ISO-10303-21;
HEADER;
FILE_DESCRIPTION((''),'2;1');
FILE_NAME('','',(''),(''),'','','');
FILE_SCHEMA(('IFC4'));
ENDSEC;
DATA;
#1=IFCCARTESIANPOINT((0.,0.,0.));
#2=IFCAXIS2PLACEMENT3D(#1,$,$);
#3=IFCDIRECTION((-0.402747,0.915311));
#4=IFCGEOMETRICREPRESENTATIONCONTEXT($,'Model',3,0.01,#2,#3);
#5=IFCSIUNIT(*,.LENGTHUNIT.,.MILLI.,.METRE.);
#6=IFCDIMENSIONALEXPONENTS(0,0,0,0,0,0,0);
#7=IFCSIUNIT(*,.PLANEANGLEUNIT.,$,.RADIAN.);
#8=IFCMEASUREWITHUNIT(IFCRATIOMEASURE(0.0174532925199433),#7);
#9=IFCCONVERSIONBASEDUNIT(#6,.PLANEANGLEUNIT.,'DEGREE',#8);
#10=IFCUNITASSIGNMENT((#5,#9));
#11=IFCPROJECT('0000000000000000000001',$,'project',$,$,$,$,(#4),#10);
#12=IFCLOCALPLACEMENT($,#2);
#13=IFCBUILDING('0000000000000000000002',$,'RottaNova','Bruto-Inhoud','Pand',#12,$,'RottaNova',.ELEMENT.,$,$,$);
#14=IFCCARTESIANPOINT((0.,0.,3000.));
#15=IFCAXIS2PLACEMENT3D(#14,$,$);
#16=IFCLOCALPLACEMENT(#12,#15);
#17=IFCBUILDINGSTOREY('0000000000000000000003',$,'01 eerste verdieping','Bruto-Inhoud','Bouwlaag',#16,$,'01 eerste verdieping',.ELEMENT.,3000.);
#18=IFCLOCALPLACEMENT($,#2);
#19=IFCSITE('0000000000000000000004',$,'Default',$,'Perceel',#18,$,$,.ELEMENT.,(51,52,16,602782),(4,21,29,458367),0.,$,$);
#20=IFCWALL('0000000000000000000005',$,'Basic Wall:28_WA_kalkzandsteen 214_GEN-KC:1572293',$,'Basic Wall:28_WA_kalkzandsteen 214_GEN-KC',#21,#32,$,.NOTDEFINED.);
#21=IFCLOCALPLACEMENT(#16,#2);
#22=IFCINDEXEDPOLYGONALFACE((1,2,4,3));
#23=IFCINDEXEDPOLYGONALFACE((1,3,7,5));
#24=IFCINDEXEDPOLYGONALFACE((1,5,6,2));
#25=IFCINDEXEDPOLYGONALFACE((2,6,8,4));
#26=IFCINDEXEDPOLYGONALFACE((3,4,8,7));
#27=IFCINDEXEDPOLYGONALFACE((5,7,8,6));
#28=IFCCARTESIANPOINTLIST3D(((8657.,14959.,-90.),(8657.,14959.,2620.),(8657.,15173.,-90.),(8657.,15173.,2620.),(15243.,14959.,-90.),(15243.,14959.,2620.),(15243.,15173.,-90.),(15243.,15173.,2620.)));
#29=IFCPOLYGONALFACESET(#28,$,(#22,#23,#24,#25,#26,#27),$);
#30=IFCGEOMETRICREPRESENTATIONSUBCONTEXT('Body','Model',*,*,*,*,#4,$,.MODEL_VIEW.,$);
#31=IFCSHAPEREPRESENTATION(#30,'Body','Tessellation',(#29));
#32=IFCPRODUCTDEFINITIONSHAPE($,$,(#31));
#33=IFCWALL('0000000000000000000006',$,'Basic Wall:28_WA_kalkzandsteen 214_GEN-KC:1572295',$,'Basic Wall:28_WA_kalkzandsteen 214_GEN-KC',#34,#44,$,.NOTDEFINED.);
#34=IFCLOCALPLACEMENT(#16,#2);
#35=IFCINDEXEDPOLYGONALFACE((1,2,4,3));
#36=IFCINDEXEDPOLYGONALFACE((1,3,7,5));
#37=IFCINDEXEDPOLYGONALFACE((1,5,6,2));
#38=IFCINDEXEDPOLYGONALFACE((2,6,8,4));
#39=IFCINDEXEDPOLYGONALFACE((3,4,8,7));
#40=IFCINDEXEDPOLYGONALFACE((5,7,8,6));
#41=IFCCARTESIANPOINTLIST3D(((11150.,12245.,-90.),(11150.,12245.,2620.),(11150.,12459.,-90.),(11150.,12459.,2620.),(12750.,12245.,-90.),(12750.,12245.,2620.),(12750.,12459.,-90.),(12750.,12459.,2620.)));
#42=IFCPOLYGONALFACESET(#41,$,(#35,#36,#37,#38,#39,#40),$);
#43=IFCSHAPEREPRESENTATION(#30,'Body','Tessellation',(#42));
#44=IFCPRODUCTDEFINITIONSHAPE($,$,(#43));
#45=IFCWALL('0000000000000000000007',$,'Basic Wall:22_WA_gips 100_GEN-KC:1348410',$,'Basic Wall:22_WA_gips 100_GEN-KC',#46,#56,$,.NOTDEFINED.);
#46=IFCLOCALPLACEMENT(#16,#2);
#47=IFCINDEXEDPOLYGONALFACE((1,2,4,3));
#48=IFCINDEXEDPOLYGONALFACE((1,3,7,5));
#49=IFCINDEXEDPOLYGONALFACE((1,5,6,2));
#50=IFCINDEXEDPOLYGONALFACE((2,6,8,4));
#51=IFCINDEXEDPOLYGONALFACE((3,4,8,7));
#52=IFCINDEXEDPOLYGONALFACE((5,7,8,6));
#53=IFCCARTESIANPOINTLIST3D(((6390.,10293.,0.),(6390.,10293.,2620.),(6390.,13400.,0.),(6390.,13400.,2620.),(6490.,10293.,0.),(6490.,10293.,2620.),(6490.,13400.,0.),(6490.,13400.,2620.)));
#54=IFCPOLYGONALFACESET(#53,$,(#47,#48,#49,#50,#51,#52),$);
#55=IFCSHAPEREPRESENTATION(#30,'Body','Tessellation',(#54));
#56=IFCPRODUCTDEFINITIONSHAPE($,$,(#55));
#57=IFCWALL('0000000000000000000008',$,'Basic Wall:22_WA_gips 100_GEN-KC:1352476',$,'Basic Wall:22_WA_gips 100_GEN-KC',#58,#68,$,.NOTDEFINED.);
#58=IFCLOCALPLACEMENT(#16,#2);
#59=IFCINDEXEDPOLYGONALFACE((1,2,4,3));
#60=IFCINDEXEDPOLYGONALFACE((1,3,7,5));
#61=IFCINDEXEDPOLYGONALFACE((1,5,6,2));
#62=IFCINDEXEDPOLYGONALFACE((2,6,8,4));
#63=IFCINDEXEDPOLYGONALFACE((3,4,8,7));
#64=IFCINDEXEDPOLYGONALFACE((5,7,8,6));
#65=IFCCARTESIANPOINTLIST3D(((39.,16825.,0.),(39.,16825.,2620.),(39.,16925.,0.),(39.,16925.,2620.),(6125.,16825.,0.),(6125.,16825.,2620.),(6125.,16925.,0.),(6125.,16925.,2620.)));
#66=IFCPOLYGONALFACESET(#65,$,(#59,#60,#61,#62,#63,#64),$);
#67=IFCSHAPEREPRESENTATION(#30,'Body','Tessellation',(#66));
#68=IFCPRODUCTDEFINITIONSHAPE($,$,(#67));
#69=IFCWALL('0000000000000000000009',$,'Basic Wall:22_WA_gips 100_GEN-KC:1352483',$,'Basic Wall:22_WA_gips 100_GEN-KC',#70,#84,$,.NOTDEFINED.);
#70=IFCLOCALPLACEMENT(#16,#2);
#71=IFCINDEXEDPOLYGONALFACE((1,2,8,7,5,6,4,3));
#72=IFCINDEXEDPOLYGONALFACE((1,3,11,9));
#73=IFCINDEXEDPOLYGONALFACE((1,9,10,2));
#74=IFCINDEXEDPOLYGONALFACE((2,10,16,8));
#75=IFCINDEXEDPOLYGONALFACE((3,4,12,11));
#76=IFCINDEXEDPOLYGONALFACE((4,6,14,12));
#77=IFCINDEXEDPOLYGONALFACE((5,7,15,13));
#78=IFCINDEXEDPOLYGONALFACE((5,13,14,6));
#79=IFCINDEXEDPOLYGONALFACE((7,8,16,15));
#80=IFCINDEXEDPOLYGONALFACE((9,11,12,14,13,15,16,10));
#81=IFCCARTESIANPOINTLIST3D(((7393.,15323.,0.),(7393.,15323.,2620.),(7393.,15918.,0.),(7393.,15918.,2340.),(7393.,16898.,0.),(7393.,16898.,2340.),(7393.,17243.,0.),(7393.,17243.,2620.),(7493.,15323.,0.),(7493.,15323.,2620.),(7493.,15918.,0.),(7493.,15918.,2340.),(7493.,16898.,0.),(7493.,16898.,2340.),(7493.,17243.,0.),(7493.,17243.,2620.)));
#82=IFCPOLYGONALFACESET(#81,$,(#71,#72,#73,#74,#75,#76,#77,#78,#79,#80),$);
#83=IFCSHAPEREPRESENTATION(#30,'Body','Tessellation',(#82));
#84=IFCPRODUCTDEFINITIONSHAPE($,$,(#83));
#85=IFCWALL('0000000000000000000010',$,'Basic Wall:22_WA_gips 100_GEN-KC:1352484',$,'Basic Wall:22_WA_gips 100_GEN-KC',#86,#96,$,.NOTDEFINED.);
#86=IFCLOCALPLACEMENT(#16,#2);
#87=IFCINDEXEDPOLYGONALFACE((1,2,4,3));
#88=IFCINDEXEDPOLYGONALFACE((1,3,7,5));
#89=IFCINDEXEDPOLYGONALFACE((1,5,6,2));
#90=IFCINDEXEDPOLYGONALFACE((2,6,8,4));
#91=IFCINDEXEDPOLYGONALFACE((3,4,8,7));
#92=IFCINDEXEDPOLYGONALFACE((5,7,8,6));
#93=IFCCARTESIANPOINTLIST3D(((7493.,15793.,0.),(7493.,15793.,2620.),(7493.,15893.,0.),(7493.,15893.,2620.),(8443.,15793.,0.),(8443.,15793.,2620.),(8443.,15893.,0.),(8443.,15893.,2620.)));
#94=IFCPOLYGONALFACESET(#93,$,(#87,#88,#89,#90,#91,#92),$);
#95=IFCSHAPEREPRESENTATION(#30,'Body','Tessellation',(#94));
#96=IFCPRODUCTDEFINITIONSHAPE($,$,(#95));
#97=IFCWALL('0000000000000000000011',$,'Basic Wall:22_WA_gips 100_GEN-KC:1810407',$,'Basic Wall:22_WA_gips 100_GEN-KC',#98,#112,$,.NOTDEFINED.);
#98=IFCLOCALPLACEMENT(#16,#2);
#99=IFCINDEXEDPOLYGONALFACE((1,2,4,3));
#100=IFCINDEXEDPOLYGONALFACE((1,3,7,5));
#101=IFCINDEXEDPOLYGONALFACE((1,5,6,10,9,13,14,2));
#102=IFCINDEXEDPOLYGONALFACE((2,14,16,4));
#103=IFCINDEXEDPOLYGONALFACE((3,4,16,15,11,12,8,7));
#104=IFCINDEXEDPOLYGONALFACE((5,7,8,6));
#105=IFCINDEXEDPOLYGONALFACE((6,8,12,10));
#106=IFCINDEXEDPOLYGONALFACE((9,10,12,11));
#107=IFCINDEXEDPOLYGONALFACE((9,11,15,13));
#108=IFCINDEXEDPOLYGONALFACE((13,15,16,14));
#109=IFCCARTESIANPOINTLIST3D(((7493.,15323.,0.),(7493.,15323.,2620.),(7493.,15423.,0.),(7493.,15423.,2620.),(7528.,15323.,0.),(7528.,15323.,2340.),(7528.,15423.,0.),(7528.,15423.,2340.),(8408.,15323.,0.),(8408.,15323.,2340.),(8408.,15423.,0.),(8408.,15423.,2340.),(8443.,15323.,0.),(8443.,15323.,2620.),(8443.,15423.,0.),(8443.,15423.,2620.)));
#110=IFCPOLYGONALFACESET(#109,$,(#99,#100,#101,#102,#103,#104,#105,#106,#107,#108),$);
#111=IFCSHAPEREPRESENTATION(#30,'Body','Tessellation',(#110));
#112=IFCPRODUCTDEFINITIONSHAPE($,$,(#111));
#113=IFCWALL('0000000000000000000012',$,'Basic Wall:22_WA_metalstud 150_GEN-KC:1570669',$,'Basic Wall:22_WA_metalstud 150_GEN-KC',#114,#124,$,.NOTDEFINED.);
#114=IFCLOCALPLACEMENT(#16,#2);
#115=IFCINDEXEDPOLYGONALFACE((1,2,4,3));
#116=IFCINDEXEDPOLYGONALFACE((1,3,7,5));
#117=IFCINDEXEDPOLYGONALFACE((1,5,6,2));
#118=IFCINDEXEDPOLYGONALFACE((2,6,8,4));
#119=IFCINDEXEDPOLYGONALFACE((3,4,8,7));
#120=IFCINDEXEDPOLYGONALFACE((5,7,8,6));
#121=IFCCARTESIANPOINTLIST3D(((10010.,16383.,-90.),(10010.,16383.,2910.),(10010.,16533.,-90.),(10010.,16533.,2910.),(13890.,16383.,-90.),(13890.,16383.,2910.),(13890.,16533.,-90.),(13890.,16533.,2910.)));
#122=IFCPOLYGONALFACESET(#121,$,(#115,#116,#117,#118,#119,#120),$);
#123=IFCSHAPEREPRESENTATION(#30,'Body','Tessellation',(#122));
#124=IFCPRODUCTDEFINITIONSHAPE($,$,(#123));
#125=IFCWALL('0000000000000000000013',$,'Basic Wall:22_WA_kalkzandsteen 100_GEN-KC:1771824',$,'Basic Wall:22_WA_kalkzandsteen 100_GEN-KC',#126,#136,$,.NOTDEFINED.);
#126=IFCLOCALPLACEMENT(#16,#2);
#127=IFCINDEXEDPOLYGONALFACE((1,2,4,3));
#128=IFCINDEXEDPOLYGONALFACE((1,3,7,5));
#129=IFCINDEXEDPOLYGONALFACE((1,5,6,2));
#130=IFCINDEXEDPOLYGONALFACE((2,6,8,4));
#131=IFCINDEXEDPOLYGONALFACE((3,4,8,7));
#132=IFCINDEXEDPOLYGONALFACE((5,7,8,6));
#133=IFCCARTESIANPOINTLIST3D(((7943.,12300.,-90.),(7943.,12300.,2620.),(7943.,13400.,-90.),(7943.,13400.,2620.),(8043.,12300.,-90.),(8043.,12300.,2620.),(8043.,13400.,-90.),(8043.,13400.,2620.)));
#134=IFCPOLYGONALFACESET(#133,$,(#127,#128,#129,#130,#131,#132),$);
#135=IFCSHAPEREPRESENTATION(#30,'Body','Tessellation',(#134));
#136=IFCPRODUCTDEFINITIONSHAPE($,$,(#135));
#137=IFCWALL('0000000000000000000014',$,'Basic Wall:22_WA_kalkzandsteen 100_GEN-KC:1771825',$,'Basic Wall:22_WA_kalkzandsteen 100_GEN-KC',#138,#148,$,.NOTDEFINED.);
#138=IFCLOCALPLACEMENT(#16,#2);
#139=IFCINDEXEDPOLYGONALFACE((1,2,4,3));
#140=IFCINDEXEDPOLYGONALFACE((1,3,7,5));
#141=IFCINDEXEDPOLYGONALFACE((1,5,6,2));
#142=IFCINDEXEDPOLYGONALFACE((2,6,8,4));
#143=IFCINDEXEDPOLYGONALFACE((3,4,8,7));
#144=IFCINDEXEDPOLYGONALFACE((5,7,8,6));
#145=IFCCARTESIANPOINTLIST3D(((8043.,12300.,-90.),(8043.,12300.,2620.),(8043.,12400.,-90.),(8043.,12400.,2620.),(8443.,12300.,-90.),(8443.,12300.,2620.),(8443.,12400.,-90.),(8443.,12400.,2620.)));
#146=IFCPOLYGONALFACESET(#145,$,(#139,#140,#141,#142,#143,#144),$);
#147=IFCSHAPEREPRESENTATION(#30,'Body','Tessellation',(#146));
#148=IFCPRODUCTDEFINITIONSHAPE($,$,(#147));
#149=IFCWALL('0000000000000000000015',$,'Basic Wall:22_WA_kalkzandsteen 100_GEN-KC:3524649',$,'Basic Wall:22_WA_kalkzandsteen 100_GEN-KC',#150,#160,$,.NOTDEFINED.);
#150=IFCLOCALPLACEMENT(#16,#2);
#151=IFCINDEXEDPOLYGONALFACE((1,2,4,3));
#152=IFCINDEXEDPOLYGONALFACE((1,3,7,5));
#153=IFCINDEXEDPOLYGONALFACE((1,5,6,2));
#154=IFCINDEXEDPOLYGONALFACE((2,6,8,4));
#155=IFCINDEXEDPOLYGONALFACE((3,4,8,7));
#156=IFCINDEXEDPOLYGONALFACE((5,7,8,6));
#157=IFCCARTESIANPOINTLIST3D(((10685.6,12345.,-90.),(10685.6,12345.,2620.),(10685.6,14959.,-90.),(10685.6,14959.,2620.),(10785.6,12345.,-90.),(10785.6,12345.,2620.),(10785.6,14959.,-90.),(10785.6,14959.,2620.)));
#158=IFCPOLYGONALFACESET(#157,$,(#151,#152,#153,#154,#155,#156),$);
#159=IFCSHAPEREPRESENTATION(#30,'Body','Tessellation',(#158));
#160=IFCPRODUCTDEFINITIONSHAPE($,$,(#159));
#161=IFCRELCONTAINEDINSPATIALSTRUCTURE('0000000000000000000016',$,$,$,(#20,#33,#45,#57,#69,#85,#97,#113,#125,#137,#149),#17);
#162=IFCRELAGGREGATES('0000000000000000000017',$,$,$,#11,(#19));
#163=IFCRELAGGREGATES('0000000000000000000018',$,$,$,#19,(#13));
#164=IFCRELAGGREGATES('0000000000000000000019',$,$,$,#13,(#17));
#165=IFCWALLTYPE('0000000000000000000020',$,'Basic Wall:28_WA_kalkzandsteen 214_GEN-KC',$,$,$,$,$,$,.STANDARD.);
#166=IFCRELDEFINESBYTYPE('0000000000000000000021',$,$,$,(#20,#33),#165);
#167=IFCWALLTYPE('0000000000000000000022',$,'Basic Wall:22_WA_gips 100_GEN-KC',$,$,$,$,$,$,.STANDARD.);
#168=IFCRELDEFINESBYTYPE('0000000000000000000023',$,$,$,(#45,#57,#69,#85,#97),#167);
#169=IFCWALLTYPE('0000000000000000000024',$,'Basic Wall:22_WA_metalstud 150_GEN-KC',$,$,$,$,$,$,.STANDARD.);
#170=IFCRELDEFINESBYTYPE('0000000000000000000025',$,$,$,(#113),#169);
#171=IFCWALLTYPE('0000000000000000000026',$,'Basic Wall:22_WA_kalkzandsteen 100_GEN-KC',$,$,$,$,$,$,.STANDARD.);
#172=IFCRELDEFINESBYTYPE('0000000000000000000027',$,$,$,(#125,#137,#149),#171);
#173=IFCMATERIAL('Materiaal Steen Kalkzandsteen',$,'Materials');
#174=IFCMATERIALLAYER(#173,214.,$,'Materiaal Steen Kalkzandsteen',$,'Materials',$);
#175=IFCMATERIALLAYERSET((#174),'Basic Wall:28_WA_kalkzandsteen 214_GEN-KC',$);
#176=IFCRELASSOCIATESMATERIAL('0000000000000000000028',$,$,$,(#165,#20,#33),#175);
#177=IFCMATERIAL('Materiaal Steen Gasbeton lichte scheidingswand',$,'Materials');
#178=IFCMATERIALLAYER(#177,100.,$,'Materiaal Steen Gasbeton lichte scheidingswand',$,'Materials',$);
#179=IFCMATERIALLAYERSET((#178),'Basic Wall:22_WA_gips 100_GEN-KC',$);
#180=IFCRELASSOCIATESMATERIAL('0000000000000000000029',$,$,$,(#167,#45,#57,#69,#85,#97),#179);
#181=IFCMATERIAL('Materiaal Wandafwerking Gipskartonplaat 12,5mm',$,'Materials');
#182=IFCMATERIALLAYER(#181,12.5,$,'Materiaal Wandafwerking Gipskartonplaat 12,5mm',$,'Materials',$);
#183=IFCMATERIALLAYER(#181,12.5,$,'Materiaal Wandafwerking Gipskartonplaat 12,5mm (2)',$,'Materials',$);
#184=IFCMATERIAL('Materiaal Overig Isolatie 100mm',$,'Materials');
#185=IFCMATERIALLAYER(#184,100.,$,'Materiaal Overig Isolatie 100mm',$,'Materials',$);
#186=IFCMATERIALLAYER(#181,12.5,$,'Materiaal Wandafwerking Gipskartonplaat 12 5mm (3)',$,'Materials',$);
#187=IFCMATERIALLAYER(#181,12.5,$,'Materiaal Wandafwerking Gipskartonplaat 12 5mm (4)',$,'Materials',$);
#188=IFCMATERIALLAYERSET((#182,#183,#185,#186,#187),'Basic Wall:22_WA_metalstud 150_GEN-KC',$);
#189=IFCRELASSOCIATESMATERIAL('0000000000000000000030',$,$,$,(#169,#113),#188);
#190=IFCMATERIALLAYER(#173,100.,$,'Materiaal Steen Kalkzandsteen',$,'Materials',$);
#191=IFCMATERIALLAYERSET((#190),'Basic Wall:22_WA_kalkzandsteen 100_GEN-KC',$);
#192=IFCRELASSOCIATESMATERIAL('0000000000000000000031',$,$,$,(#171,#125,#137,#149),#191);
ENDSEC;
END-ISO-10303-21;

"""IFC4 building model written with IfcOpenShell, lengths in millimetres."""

from ifc_helpers import new_model, entity, si_unit, converted_unit, direction, frame, frame_2d, origin, place, context, subcontext, project, spatial, rectangle, extrude, material, layer, layer_set, type_object, element, save


model = new_model("IFC4")

# Units and contexts
model_context = context("Model", 3, precision=0.01, world=origin(), true_north=direction((-0.402747, 0.915311)))
body_context = subcontext(model_context, "Body", "Model", "MODEL_VIEW")
ifc_project = project(units=[si_unit("LENGTHUNIT", "METRE", prefix="MILLI"), converted_unit("PLANEANGLEUNIT", "DEGREE", entity("IfcRatioMeasure", 0.0174532925199433), si_unit("PLANEANGLEUNIT", "RADIAN"), dimensions=[0, 0, 0, 0, 0, 0, 0])], contexts=[model_context])

# Site, building, storey
site_placement = place(None, origin())
site = spatial("IfcSite", under=ifc_project, at=site_placement, Name="Default", ObjectType="Perceel", CompositionType="ELEMENT", RefLatitude=(51, 52, 16, 602782), RefLongitude=(4, 21, 29, 458367), RefElevation=0.0)
building_placement = place(None, origin())
building = spatial("IfcBuilding", under=site, at=building_placement, Name="RottaNova", Description="Bruto-Inhoud", ObjectType="Pand", LongName="RottaNova", CompositionType="ELEMENT")
storey_placement = place(building_placement, frame((0.0, 0.0, 3000.0)))
storey = spatial("IfcBuildingStorey", under=building, at=storey_placement, Name="01 eerste verdieping", Description="Bruto-Inhoud", ObjectType="Bouwlaag", LongName="01 eerste verdieping", CompositionType="ELEMENT", Elevation=3000.0)

# Walls
ifc_material_1 = material(Name="Materiaal Steen Kalkzandsteen", Category="Materials")
ifc_layer_1 = layer(ifc_material_1, 214.0, Name="Materiaal Steen Kalkzandsteen", Category="Materials")
ifc_layer_set_1 = layer_set([ifc_layer_1], Name="Basic Wall:28_WA_kalkzandsteen 214_GEN-KC")
wall_type_1 = type_object("IfcWallType", Name="Basic Wall:28_WA_kalkzandsteen 214_GEN-KC", PredefinedType="STANDARD", material=ifc_layer_set_1)
wall_1_placement = place(storey_placement, frame((8657.0, 15066.0, -90.0)))
element("IfcWall", 1, at=wall_1_placement, inside=storey, type_object=wall_type_1, material=ifc_layer_set_1, Name="Basic Wall:28_WA_kalkzandsteen 214_GEN-KC:1572293", ObjectType="Basic Wall:28_WA_kalkzandsteen 214_GEN-KC", PredefinedType="NOTDEFINED", context=body_context, shape_type="SweptSolid", body=[
    extrude(rectangle(XDim=6586.0, YDim=214.0, at=frame_2d((3293.0, 0.0), x_axis=(1.0, 0.0))), origin(), (0.0, 0.0, 1.0), 2710.0),
])
wall_2_placement = place(storey_placement, frame((11150.0, 12352.0, -90.0)))
element("IfcWall", 2, at=wall_2_placement, inside=storey, type_object=wall_type_1, material=ifc_layer_set_1, Name="Basic Wall:28_WA_kalkzandsteen 214_GEN-KC:1572295", ObjectType="Basic Wall:28_WA_kalkzandsteen 214_GEN-KC", PredefinedType="NOTDEFINED", context=body_context, shape_type="SweptSolid", body=[
    extrude(rectangle(XDim=1600.0, YDim=214.0, at=frame_2d((800.0, 0.0), x_axis=(-1.0, 0.0))), origin(), (0.0, 0.0, 1.0), 2710.0),
])
ifc_material_2 = material(Name="Materiaal Steen Gasbeton lichte scheidingswand", Category="Materials")
ifc_layer_2 = layer(ifc_material_2, 100.0, Name="Materiaal Steen Gasbeton lichte scheidingswand", Category="Materials")
ifc_layer_set_2 = layer_set([ifc_layer_2], Name="Basic Wall:22_WA_gips 100_GEN-KC")
wall_type_2 = type_object("IfcWallType", Name="Basic Wall:22_WA_gips 100_GEN-KC", PredefinedType="STANDARD", material=ifc_layer_set_2)
wall_3_placement = place(storey_placement, frame((6440.0, 13400.0, 0.0), z_axis=(0.0, 0.0, 1.0), x_axis=(0.0, -1.0, 0.0)))
element("IfcWall", 3, at=wall_3_placement, inside=storey, type_object=wall_type_2, material=ifc_layer_set_2, Name="Basic Wall:22_WA_gips 100_GEN-KC:1348410", ObjectType="Basic Wall:22_WA_gips 100_GEN-KC", PredefinedType="NOTDEFINED", context=body_context, shape_type="SweptSolid", body=[
    extrude(rectangle(XDim=3107.0, YDim=100.0, at=frame_2d((1553.5, 0.0), x_axis=(-1.0, 0.0))), origin(), (0.0, 0.0, 1.0), 2620.0),
])
wall_4_placement = place(storey_placement, frame((39.0, 16875.0, 0.0)))
element("IfcWall", 4, at=wall_4_placement, inside=storey, type_object=wall_type_2, material=ifc_layer_set_2, Name="Basic Wall:22_WA_gips 100_GEN-KC:1352476", ObjectType="Basic Wall:22_WA_gips 100_GEN-KC", PredefinedType="NOTDEFINED", context=body_context, shape_type="SweptSolid", body=[
    extrude(rectangle(XDim=6086.0, YDim=100.0, at=frame_2d((3043.0, 0.0), x_axis=(-1.0, 0.0))), origin(), (0.0, 0.0, 1.0), 2620.0),
])

# Wall, opening
wall_5_placement = place(storey_placement, frame((7443.0, 17243.0, 0.0), z_axis=(0.0, 0.0, 1.0), x_axis=(0.0, -1.0, 0.0)))
wall_5 = element("IfcWall", 5, at=wall_5_placement, inside=storey, type_object=wall_type_2, material=ifc_layer_set_2, Name="Basic Wall:22_WA_gips 100_GEN-KC:1352483", ObjectType="Basic Wall:22_WA_gips 100_GEN-KC", PredefinedType="NOTDEFINED", context=body_context, shape_type="SweptSolid", body=[
    extrude(rectangle(XDim=1920.0, YDim=100.0, at=frame_2d((960.0, 0.0), x_axis=(1.0, 0.0))), origin(), (0.0, 0.0, 1.0), 2620.0),
])
opening_1_placement = place(wall_5_placement, frame((1325.0, 50.0, -90.0)))
element("IfcOpeningElement", 6, at=opening_1_placement, cuts=wall_5, PredefinedType="OPENING", context=body_context, shape_type="SweptSolid", body=[
    extrude(rectangle(XDim=2430.0, YDim=980.0, at=frame_2d((1215.0, 490.0), x_axis=(1.0, 0.0))), frame((0.0, 0.0, 0.0), z_axis=(0.0, -1.0, 0.0), x_axis=(0.0, 0.0, 1.0)), (0.0, 0.0, 1.0), 100.0),
])

# Wall
wall_6_placement = place(storey_placement, frame((7493.0, 15843.0, 0.0)))
element("IfcWall", 7, at=wall_6_placement, inside=storey, type_object=wall_type_2, material=ifc_layer_set_2, Name="Basic Wall:22_WA_gips 100_GEN-KC:1352484", ObjectType="Basic Wall:22_WA_gips 100_GEN-KC", PredefinedType="NOTDEFINED", context=body_context, shape_type="SweptSolid", body=[
    extrude(rectangle(XDim=950.0, YDim=100.0, at=frame_2d((475.0, 0.0), x_axis=(-1.0, 0.0))), origin(), (0.0, 0.0, 1.0), 2620.0),
])

# Wall, opening
wall_7_placement = place(storey_placement, frame((7493.0, 15373.0, 0.0)))
wall_7 = element("IfcWall", 8, at=wall_7_placement, inside=storey, type_object=wall_type_2, material=ifc_layer_set_2, Name="Basic Wall:22_WA_gips 100_GEN-KC:1810407", ObjectType="Basic Wall:22_WA_gips 100_GEN-KC", PredefinedType="NOTDEFINED", context=body_context, shape_type="SweptSolid", body=[
    extrude(rectangle(XDim=950.0, YDim=100.0, at=frame_2d((475.0, 0.0), x_axis=(-1.0, 0.0))), origin(), (0.0, 0.0, 1.0), 2620.0),
])
opening_2_placement = place(wall_7_placement, frame((915.0, 50.0, -70.0)))
element("IfcOpeningElement", 9, at=opening_2_placement, cuts=wall_7, PredefinedType="OPENING", context=body_context, shape_type="SweptSolid", body=[
    extrude(rectangle(XDim=2410.0, YDim=880.0, at=frame_2d((1205.0, 440.0), x_axis=(1.0, 0.0))), frame((0.0, 0.0, 0.0), z_axis=(0.0, -1.0, 0.0), x_axis=(0.0, 0.0, 1.0)), (0.0, 0.0, 1.0), 100.0),
])

# Walls
ifc_material_3 = material(Name="Materiaal Wandafwerking Gipskartonplaat 12,5mm", Category="Materials")
ifc_layer_3 = layer(ifc_material_3, 12.5, Name="Materiaal Wandafwerking Gipskartonplaat 12,5mm", Category="Materials")
ifc_layer_4 = layer(ifc_material_3, 12.5, Name="Materiaal Wandafwerking Gipskartonplaat 12,5mm (2)", Category="Materials")
ifc_material_4 = material(Name="Materiaal Overig Isolatie 100mm", Category="Materials")
ifc_layer_5 = layer(ifc_material_4, 100.0, Name="Materiaal Overig Isolatie 100mm", Category="Materials")
ifc_layer_6 = layer(ifc_material_3, 12.5, Name="Materiaal Wandafwerking Gipskartonplaat 12 5mm (3)", Category="Materials")
ifc_layer_7 = layer(ifc_material_3, 12.5, Name="Materiaal Wandafwerking Gipskartonplaat 12 5mm (4)", Category="Materials")
ifc_layer_set_3 = layer_set([ifc_layer_3, ifc_layer_4, ifc_layer_5, ifc_layer_6, ifc_layer_7], Name="Basic Wall:22_WA_metalstud 150_GEN-KC")
wall_type_3 = type_object("IfcWallType", Name="Basic Wall:22_WA_metalstud 150_GEN-KC", PredefinedType="STANDARD", material=ifc_layer_set_3)
wall_8_placement = place(storey_placement, frame((10010.0, 16458.0, -90.0)))
element("IfcWall", 10, at=wall_8_placement, inside=storey, type_object=wall_type_3, material=ifc_layer_set_3, Name="Basic Wall:22_WA_metalstud 150_GEN-KC:1570669", ObjectType="Basic Wall:22_WA_metalstud 150_GEN-KC", PredefinedType="NOTDEFINED", context=body_context, shape_type="SweptSolid", body=[
    extrude(rectangle(XDim=3880.0, YDim=150.0, at=frame_2d((1940.0, 0.0), x_axis=(-1.0, 0.0))), origin(), (0.0, 0.0, 1.0), 3000.0),
])
ifc_layer_8 = layer(ifc_material_1, 100.0, Name="Materiaal Steen Kalkzandsteen", Category="Materials")
ifc_layer_set_4 = layer_set([ifc_layer_8], Name="Basic Wall:22_WA_kalkzandsteen 100_GEN-KC")
wall_type_4 = type_object("IfcWallType", Name="Basic Wall:22_WA_kalkzandsteen 100_GEN-KC", PredefinedType="STANDARD", material=ifc_layer_set_4)
wall_9_placement = place(storey_placement, frame((7993.0, 13400.0, -90.0), z_axis=(0.0, 0.0, 1.0), x_axis=(0.0, -1.0, 0.0)))
element("IfcWall", 11, at=wall_9_placement, inside=storey, type_object=wall_type_4, material=ifc_layer_set_4, Name="Basic Wall:22_WA_kalkzandsteen 100_GEN-KC:1771824", ObjectType="Basic Wall:22_WA_kalkzandsteen 100_GEN-KC", PredefinedType="NOTDEFINED", context=body_context, shape_type="SweptSolid", body=[
    extrude(rectangle(XDim=1100.0, YDim=100.0, at=frame_2d((550.0, 0.0), x_axis=(-1.0, 0.0))), origin(), (0.0, 0.0, 1.0), 2710.0),
])
wall_10_placement = place(storey_placement, frame((8043.0, 12350.0, -90.0)))
element("IfcWall", 12, at=wall_10_placement, inside=storey, type_object=wall_type_4, material=ifc_layer_set_4, Name="Basic Wall:22_WA_kalkzandsteen 100_GEN-KC:1771825", ObjectType="Basic Wall:22_WA_kalkzandsteen 100_GEN-KC", PredefinedType="NOTDEFINED", context=body_context, shape_type="SweptSolid", body=[
    extrude(rectangle(XDim=400.0, YDim=100.0, at=frame_2d((200.0, 0.0), x_axis=(-1.0, 0.0))), origin(), (0.0, 0.0, 1.0), 2710.0),
])
wall_11_placement = place(storey_placement, frame((10735.6, 14959.0, -90.0), z_axis=(0.0, 0.0, 1.0), x_axis=(0.0, -1.0, 0.0)))
element("IfcWall", 13, at=wall_11_placement, inside=storey, type_object=wall_type_4, material=ifc_layer_set_4, Name="Basic Wall:22_WA_kalkzandsteen 100_GEN-KC:3524649", ObjectType="Basic Wall:22_WA_kalkzandsteen 100_GEN-KC", PredefinedType="NOTDEFINED", context=body_context, shape_type="SweptSolid", body=[
    extrude(rectangle(XDim=2614.0, YDim=100.0, at=frame_2d((1307.0, 0.0), x_axis=(-1.0, 0.0))), origin(), (0.0, 0.0, 1.0), 2710.0),
])

save(model, "model.ifc")
